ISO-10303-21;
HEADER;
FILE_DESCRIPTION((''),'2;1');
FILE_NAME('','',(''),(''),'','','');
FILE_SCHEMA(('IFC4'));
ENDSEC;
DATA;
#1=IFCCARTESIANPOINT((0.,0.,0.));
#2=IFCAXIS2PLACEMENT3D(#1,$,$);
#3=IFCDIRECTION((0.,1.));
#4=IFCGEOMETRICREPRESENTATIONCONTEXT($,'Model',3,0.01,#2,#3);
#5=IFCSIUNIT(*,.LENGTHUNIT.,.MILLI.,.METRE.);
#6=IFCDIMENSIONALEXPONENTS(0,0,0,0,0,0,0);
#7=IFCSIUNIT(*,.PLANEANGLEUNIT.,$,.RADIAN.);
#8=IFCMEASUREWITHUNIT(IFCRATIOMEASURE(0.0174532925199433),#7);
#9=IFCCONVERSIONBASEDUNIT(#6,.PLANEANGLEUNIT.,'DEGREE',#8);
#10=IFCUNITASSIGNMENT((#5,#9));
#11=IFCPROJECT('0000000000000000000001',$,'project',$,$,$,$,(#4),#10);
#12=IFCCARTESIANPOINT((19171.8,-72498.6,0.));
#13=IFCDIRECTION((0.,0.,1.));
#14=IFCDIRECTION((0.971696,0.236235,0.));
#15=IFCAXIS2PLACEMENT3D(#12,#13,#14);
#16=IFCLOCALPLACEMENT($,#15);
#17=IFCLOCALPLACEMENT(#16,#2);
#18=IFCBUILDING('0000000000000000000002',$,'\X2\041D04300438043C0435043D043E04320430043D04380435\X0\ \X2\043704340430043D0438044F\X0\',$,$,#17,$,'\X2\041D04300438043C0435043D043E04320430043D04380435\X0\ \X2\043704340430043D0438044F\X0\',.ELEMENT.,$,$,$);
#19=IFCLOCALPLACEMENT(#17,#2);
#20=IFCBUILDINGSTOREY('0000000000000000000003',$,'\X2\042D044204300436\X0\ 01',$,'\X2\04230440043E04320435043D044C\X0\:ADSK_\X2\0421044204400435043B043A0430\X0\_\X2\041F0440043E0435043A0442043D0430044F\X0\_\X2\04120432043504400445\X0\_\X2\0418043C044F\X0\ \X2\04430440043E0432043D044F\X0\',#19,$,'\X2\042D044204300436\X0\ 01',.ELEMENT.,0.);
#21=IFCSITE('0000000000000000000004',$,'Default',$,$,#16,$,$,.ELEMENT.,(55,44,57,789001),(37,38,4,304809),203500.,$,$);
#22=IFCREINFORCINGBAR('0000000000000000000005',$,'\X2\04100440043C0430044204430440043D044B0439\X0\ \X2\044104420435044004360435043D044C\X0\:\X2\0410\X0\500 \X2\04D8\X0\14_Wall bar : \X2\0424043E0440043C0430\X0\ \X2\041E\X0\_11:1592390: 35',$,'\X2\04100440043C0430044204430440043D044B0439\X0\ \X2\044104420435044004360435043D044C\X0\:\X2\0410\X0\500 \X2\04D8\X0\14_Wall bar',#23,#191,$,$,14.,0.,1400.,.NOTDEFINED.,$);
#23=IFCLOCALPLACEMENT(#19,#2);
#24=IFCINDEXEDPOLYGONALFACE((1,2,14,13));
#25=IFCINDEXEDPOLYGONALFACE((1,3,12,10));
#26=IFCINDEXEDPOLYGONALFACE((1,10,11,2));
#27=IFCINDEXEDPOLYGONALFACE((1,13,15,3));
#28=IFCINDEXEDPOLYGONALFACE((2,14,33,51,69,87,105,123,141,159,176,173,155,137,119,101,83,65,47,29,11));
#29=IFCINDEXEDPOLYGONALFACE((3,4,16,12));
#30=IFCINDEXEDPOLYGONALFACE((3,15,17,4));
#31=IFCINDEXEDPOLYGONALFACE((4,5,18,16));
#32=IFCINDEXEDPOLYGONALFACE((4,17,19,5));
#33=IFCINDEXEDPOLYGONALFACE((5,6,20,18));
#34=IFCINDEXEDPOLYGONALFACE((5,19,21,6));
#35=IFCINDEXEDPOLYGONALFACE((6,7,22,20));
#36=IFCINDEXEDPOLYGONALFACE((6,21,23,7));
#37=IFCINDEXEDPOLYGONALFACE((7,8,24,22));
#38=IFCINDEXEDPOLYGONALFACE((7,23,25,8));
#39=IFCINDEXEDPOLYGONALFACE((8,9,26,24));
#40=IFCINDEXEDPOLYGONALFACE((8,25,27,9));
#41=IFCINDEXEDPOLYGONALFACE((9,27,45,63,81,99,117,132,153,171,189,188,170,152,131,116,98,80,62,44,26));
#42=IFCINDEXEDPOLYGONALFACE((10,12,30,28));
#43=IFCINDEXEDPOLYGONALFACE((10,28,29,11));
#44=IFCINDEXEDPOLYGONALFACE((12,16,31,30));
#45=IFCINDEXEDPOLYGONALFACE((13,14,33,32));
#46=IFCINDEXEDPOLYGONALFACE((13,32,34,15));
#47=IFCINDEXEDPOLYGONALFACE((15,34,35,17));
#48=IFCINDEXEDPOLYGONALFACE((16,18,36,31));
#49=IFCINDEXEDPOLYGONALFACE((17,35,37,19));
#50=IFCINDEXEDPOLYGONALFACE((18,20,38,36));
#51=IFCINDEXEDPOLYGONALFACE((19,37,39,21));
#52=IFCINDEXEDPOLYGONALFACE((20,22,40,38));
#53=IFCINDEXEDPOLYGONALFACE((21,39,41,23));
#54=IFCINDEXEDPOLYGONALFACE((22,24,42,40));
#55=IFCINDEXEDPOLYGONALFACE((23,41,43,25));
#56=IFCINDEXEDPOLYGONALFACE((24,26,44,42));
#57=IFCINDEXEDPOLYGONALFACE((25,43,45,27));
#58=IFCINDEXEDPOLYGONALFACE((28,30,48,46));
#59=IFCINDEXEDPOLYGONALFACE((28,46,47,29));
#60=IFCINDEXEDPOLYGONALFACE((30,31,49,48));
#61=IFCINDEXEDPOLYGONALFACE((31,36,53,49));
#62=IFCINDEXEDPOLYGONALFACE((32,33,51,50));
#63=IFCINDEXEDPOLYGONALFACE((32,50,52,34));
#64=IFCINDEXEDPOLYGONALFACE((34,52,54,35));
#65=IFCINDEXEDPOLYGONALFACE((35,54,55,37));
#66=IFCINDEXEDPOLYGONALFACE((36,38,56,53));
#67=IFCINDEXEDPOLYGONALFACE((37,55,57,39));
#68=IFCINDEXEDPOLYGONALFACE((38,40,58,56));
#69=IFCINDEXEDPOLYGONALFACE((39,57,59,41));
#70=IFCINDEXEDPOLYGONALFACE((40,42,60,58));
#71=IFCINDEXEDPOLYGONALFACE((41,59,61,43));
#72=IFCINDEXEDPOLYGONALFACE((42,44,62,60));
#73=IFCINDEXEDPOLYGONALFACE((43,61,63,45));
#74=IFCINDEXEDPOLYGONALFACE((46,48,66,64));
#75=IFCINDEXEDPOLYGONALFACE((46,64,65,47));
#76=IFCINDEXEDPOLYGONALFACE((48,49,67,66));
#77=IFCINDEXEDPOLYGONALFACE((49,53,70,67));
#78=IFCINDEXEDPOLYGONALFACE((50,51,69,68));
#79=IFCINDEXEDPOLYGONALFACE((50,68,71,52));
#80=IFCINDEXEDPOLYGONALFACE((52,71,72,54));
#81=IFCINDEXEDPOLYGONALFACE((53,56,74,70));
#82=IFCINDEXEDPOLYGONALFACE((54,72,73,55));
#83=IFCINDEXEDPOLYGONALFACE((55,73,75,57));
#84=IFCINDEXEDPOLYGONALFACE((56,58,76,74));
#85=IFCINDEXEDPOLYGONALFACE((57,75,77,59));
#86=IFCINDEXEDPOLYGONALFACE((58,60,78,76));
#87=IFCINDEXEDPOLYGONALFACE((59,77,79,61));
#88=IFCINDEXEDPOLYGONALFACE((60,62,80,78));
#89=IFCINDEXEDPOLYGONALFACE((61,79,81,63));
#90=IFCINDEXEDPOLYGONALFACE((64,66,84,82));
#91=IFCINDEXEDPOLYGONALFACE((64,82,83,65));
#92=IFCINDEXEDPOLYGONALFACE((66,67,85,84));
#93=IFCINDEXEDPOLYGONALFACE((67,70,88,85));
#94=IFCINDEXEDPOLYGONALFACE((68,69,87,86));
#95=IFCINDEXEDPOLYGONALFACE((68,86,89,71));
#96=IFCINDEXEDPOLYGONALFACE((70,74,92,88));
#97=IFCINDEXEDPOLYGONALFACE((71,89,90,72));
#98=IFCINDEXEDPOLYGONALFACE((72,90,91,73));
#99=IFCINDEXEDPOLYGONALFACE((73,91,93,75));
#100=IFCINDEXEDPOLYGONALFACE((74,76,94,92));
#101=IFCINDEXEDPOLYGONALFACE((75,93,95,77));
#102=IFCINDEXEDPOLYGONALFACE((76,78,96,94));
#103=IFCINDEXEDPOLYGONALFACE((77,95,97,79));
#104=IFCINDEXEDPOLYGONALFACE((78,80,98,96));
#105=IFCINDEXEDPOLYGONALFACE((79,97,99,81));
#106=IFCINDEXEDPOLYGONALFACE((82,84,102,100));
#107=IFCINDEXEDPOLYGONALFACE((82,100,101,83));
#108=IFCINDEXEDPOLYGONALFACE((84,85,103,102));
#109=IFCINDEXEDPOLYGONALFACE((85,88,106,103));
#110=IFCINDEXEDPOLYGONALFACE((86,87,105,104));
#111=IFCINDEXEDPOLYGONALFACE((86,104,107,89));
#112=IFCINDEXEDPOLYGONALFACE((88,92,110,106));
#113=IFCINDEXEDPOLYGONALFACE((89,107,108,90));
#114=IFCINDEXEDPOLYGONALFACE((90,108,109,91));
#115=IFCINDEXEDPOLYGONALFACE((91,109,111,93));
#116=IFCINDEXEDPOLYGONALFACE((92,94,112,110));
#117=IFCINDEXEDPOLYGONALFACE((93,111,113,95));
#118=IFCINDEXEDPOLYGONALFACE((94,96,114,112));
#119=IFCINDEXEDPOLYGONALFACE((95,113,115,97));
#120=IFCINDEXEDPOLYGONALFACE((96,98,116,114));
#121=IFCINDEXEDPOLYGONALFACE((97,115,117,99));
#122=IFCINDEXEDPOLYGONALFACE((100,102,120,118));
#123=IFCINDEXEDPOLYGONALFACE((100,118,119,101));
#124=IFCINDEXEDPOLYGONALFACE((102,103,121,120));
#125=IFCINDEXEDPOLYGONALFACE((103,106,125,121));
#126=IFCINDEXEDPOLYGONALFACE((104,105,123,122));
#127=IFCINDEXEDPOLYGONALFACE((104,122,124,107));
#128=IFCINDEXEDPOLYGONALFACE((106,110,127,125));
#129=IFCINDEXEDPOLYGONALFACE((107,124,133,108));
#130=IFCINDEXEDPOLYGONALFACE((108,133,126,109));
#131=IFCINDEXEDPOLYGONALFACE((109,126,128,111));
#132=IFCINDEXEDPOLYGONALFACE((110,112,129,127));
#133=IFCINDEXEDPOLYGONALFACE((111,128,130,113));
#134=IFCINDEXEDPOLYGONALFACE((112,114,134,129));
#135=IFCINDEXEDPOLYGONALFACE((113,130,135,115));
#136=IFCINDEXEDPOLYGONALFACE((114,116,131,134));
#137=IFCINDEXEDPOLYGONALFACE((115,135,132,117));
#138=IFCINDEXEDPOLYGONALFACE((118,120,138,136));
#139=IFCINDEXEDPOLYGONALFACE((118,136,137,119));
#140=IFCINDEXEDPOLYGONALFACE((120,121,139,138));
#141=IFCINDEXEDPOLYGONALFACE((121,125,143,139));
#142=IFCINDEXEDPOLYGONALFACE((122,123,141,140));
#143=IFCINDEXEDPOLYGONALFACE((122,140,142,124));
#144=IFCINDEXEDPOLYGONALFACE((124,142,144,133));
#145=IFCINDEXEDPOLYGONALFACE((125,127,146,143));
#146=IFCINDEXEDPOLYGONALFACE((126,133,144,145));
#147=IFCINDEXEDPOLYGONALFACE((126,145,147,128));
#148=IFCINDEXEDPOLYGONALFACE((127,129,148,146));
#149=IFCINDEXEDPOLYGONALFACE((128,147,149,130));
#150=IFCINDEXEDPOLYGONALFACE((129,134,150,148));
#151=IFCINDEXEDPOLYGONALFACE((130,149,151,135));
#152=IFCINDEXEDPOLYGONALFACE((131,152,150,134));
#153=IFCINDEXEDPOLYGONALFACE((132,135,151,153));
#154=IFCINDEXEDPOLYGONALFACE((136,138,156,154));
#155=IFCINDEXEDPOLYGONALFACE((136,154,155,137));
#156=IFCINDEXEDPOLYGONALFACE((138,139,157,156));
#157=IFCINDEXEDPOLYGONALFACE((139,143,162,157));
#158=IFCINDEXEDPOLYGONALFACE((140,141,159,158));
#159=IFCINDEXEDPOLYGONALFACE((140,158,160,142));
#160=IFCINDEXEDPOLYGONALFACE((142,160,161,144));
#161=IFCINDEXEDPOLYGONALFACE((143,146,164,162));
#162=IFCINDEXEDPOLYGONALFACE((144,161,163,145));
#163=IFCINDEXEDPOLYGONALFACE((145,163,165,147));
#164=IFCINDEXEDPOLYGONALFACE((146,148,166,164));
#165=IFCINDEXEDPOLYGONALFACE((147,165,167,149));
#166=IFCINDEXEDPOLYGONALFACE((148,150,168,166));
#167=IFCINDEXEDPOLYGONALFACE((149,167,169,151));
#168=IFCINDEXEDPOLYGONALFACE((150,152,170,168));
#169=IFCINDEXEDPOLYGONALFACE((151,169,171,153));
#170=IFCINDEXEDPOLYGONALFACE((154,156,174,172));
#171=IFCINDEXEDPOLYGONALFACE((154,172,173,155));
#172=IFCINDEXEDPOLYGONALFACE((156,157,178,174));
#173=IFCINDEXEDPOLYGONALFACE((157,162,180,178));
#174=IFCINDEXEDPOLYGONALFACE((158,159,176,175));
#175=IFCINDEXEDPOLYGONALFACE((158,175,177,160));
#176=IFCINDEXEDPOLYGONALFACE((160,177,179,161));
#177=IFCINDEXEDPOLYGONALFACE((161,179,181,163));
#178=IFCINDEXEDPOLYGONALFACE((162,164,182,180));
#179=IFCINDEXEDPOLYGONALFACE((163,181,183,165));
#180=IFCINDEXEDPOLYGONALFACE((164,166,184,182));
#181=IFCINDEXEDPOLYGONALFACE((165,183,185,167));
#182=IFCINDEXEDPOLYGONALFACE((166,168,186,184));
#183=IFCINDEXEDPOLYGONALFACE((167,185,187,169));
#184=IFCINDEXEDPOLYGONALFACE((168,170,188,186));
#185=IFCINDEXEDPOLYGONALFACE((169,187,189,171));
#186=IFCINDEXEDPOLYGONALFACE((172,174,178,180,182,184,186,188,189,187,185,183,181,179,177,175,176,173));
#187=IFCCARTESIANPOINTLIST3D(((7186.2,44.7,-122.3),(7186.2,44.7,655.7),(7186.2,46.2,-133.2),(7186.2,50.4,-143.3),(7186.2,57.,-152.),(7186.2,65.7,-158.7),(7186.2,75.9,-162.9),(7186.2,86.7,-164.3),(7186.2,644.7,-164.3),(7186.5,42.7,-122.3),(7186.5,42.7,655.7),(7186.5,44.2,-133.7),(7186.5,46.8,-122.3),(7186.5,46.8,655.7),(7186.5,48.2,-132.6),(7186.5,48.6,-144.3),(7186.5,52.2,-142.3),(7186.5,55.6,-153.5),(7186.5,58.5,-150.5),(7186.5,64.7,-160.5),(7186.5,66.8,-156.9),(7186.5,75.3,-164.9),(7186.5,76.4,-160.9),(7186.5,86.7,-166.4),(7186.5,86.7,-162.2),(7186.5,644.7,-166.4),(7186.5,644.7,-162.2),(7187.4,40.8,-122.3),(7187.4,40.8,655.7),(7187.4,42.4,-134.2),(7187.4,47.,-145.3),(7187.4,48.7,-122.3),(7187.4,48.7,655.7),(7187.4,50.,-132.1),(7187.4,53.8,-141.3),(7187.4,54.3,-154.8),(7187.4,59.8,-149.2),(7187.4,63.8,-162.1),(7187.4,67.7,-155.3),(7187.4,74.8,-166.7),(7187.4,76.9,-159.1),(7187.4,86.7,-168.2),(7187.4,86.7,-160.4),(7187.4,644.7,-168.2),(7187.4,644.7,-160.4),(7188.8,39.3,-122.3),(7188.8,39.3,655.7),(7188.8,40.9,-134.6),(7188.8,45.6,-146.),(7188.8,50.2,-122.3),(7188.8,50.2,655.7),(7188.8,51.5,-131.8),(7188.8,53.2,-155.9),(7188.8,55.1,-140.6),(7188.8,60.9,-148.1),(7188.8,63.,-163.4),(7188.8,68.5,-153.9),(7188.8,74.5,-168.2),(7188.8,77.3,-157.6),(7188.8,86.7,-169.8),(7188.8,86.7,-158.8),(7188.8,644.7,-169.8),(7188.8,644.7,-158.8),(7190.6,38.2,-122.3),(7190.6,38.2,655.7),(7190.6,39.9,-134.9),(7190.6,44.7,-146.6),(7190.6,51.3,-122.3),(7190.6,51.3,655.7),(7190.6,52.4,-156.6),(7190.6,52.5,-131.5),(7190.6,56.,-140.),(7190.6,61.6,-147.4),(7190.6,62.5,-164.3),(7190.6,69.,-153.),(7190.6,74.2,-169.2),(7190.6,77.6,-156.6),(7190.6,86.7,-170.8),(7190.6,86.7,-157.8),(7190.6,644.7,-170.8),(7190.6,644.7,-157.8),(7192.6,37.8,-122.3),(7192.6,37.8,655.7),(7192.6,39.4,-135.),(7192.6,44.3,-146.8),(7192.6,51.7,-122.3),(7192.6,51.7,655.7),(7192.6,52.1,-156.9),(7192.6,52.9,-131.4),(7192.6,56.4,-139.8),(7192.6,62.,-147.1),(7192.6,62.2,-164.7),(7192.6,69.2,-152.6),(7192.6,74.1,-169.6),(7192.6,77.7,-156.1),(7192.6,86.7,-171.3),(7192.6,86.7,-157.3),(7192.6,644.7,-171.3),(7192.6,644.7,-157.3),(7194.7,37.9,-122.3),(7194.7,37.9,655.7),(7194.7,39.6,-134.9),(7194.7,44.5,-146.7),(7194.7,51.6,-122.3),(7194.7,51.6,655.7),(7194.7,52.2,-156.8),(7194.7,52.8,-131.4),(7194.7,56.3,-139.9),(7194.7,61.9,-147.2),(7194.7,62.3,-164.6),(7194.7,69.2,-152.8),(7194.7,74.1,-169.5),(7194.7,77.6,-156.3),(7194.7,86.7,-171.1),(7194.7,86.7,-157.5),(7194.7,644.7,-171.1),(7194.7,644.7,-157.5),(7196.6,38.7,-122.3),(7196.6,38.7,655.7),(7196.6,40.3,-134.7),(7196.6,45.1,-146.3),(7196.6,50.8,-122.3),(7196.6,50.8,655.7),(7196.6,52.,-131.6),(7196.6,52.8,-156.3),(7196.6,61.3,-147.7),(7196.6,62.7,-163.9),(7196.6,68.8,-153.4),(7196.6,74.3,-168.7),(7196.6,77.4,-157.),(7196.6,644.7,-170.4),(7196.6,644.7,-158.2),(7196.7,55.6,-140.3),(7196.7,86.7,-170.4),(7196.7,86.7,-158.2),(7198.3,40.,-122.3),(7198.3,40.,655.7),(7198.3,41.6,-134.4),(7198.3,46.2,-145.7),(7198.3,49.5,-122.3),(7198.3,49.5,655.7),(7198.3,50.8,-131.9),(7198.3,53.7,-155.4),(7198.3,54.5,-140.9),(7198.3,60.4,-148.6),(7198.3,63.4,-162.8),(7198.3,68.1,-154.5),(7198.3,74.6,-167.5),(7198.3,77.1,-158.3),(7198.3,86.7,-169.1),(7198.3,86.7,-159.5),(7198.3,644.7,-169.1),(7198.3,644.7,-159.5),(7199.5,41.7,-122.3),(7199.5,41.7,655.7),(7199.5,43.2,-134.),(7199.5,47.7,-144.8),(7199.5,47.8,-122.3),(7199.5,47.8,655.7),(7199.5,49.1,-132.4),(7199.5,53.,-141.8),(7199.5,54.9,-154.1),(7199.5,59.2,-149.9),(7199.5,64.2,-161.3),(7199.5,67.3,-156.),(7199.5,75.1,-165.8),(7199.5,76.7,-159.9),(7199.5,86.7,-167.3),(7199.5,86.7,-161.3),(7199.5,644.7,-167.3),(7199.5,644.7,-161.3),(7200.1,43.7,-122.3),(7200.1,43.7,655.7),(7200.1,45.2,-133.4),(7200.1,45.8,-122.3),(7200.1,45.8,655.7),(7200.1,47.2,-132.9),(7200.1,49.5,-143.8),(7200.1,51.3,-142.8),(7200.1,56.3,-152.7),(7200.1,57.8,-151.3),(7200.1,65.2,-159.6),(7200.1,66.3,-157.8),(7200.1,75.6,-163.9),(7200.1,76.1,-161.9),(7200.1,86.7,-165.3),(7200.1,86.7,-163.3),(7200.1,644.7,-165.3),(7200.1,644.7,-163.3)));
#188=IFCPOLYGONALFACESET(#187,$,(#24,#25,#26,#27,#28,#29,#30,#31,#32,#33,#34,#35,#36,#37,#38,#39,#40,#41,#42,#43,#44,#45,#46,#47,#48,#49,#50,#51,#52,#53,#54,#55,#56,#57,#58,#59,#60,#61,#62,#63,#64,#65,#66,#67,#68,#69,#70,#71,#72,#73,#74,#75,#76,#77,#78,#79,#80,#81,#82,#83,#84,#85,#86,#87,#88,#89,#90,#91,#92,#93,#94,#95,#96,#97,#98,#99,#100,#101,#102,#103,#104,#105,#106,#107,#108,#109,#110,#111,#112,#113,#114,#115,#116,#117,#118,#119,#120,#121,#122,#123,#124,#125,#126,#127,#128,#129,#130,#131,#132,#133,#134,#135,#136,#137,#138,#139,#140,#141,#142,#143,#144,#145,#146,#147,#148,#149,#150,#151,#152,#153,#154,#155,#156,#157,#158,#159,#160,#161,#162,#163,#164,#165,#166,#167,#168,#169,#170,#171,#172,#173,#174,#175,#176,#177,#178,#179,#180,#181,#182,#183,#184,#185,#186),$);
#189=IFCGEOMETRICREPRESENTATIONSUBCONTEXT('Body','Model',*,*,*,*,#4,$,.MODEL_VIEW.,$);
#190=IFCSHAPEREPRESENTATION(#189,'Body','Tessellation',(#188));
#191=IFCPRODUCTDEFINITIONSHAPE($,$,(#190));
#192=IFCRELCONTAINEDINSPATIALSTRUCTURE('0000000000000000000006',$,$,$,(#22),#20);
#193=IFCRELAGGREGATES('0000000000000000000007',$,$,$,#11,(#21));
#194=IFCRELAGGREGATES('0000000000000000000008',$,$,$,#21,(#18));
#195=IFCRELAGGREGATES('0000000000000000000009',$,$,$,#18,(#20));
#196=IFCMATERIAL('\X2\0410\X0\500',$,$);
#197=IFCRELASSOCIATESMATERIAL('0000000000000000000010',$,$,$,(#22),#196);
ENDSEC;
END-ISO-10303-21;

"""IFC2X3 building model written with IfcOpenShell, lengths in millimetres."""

from ifc_helpers import new_model, entity, si_unit, converted_unit, direction, frame, origin, place, context, subcontext, project, spatial, material, element, save


model = new_model("IFC2X3")

# Units and contexts
model_context = context("Model", 3, precision=0.01, world=origin(), true_north=direction((0.0, 1.0)))
body_context = subcontext(model_context, "Body", "Model", "MODEL_VIEW")
ifc_project = project(units=[si_unit("LENGTHUNIT", "METRE", prefix="MILLI"), converted_unit("PLANEANGLEUNIT", "DEGREE", entity("IfcRatioMeasure", 0.0174532925199433), si_unit("PLANEANGLEUNIT", "RADIAN"), dimensions=[0, 0, 0, 0, 0, 0, 0])], contexts=[model_context])

# Site, building, storey
site_placement = place(None, frame((19171.8, -72498.6, 0.0), z_axis=(0.0, 0.0, 1.0), x_axis=(0.971696, 0.236235, 0.0)))
site = spatial("IfcSite", under=ifc_project, at=site_placement, Name="Default", CompositionType="ELEMENT", RefLatitude=(55, 44, 57, 789001), RefLongitude=(37, 38, 4, 304809), RefElevation=203500.0)
building_placement = place(site_placement, origin())
building = spatial("IfcBuilding", under=site, at=building_placement, Name="Наименование здания", LongName="Наименование здания", CompositionType="ELEMENT")
storey_placement = place(building_placement, origin())
storey = spatial("IfcBuildingStorey", under=building, at=storey_placement, Name="Этаж 01", ObjectType="Уровень:ADSK_Стрелка_Проектная_Вверх_Имя уровня", LongName="Этаж 01", CompositionType="ELEMENT", Elevation=0.0)

# Reinforcing bar
ifc_material = material(Name="А500")
placement = place(storey_placement, origin())
element("IfcReinforcingBar", 1, at=placement, inside=storey, material=ifc_material, Name="Арматурный стержень:А500 Ә14_Wall bar : Форма О_11:1592390: 35", ObjectType="Арматурный стержень:А500 Ә14_Wall bar", BarLength=1400.0, BarRole="NOTDEFINED", CrossSectionArea=0.0, NominalDiameter=14.0, context=body_context, shape_type="AdvancedSweptSolid", body=[
    entity("IfcSweptDiskSolid", entity("IfcCompositeCurve", [entity("IfcCompositeCurveSegment", "CONTINUOUS", True, entity("IfcPolyline", [entity("IfcCartesianPoint", [7193.1, 44.7, 655.7]), entity("IfcCartesianPoint", [7193.1, 44.7, -122.3])])), entity("IfcCompositeCurveSegment", "CONTINUOUS", True, entity("IfcTrimmedCurve", entity("IfcCircle", entity("IfcAxis2Placement3D", entity("IfcCartesianPoint", [7193.1, 86.7, -122.3]), entity("IfcDirection", [1.0, 0.0, 0.0]), entity("IfcDirection", [0.0, 0.0, -1.0])), 42.0), [entity("IfcParameterValue", 270.0)], [entity("IfcParameterValue", 360.0)], True, "PARAMETER")), entity("IfcCompositeCurveSegment", "CONTINUOUS", True, entity("IfcPolyline", [entity("IfcCartesianPoint", [7193.1, 86.7, -164.3]), entity("IfcCartesianPoint", [7193.1, 644.7, -164.3])]))], False), 7.0, None, 0.0, 92.0),
])

save(model, "model.ifc")
